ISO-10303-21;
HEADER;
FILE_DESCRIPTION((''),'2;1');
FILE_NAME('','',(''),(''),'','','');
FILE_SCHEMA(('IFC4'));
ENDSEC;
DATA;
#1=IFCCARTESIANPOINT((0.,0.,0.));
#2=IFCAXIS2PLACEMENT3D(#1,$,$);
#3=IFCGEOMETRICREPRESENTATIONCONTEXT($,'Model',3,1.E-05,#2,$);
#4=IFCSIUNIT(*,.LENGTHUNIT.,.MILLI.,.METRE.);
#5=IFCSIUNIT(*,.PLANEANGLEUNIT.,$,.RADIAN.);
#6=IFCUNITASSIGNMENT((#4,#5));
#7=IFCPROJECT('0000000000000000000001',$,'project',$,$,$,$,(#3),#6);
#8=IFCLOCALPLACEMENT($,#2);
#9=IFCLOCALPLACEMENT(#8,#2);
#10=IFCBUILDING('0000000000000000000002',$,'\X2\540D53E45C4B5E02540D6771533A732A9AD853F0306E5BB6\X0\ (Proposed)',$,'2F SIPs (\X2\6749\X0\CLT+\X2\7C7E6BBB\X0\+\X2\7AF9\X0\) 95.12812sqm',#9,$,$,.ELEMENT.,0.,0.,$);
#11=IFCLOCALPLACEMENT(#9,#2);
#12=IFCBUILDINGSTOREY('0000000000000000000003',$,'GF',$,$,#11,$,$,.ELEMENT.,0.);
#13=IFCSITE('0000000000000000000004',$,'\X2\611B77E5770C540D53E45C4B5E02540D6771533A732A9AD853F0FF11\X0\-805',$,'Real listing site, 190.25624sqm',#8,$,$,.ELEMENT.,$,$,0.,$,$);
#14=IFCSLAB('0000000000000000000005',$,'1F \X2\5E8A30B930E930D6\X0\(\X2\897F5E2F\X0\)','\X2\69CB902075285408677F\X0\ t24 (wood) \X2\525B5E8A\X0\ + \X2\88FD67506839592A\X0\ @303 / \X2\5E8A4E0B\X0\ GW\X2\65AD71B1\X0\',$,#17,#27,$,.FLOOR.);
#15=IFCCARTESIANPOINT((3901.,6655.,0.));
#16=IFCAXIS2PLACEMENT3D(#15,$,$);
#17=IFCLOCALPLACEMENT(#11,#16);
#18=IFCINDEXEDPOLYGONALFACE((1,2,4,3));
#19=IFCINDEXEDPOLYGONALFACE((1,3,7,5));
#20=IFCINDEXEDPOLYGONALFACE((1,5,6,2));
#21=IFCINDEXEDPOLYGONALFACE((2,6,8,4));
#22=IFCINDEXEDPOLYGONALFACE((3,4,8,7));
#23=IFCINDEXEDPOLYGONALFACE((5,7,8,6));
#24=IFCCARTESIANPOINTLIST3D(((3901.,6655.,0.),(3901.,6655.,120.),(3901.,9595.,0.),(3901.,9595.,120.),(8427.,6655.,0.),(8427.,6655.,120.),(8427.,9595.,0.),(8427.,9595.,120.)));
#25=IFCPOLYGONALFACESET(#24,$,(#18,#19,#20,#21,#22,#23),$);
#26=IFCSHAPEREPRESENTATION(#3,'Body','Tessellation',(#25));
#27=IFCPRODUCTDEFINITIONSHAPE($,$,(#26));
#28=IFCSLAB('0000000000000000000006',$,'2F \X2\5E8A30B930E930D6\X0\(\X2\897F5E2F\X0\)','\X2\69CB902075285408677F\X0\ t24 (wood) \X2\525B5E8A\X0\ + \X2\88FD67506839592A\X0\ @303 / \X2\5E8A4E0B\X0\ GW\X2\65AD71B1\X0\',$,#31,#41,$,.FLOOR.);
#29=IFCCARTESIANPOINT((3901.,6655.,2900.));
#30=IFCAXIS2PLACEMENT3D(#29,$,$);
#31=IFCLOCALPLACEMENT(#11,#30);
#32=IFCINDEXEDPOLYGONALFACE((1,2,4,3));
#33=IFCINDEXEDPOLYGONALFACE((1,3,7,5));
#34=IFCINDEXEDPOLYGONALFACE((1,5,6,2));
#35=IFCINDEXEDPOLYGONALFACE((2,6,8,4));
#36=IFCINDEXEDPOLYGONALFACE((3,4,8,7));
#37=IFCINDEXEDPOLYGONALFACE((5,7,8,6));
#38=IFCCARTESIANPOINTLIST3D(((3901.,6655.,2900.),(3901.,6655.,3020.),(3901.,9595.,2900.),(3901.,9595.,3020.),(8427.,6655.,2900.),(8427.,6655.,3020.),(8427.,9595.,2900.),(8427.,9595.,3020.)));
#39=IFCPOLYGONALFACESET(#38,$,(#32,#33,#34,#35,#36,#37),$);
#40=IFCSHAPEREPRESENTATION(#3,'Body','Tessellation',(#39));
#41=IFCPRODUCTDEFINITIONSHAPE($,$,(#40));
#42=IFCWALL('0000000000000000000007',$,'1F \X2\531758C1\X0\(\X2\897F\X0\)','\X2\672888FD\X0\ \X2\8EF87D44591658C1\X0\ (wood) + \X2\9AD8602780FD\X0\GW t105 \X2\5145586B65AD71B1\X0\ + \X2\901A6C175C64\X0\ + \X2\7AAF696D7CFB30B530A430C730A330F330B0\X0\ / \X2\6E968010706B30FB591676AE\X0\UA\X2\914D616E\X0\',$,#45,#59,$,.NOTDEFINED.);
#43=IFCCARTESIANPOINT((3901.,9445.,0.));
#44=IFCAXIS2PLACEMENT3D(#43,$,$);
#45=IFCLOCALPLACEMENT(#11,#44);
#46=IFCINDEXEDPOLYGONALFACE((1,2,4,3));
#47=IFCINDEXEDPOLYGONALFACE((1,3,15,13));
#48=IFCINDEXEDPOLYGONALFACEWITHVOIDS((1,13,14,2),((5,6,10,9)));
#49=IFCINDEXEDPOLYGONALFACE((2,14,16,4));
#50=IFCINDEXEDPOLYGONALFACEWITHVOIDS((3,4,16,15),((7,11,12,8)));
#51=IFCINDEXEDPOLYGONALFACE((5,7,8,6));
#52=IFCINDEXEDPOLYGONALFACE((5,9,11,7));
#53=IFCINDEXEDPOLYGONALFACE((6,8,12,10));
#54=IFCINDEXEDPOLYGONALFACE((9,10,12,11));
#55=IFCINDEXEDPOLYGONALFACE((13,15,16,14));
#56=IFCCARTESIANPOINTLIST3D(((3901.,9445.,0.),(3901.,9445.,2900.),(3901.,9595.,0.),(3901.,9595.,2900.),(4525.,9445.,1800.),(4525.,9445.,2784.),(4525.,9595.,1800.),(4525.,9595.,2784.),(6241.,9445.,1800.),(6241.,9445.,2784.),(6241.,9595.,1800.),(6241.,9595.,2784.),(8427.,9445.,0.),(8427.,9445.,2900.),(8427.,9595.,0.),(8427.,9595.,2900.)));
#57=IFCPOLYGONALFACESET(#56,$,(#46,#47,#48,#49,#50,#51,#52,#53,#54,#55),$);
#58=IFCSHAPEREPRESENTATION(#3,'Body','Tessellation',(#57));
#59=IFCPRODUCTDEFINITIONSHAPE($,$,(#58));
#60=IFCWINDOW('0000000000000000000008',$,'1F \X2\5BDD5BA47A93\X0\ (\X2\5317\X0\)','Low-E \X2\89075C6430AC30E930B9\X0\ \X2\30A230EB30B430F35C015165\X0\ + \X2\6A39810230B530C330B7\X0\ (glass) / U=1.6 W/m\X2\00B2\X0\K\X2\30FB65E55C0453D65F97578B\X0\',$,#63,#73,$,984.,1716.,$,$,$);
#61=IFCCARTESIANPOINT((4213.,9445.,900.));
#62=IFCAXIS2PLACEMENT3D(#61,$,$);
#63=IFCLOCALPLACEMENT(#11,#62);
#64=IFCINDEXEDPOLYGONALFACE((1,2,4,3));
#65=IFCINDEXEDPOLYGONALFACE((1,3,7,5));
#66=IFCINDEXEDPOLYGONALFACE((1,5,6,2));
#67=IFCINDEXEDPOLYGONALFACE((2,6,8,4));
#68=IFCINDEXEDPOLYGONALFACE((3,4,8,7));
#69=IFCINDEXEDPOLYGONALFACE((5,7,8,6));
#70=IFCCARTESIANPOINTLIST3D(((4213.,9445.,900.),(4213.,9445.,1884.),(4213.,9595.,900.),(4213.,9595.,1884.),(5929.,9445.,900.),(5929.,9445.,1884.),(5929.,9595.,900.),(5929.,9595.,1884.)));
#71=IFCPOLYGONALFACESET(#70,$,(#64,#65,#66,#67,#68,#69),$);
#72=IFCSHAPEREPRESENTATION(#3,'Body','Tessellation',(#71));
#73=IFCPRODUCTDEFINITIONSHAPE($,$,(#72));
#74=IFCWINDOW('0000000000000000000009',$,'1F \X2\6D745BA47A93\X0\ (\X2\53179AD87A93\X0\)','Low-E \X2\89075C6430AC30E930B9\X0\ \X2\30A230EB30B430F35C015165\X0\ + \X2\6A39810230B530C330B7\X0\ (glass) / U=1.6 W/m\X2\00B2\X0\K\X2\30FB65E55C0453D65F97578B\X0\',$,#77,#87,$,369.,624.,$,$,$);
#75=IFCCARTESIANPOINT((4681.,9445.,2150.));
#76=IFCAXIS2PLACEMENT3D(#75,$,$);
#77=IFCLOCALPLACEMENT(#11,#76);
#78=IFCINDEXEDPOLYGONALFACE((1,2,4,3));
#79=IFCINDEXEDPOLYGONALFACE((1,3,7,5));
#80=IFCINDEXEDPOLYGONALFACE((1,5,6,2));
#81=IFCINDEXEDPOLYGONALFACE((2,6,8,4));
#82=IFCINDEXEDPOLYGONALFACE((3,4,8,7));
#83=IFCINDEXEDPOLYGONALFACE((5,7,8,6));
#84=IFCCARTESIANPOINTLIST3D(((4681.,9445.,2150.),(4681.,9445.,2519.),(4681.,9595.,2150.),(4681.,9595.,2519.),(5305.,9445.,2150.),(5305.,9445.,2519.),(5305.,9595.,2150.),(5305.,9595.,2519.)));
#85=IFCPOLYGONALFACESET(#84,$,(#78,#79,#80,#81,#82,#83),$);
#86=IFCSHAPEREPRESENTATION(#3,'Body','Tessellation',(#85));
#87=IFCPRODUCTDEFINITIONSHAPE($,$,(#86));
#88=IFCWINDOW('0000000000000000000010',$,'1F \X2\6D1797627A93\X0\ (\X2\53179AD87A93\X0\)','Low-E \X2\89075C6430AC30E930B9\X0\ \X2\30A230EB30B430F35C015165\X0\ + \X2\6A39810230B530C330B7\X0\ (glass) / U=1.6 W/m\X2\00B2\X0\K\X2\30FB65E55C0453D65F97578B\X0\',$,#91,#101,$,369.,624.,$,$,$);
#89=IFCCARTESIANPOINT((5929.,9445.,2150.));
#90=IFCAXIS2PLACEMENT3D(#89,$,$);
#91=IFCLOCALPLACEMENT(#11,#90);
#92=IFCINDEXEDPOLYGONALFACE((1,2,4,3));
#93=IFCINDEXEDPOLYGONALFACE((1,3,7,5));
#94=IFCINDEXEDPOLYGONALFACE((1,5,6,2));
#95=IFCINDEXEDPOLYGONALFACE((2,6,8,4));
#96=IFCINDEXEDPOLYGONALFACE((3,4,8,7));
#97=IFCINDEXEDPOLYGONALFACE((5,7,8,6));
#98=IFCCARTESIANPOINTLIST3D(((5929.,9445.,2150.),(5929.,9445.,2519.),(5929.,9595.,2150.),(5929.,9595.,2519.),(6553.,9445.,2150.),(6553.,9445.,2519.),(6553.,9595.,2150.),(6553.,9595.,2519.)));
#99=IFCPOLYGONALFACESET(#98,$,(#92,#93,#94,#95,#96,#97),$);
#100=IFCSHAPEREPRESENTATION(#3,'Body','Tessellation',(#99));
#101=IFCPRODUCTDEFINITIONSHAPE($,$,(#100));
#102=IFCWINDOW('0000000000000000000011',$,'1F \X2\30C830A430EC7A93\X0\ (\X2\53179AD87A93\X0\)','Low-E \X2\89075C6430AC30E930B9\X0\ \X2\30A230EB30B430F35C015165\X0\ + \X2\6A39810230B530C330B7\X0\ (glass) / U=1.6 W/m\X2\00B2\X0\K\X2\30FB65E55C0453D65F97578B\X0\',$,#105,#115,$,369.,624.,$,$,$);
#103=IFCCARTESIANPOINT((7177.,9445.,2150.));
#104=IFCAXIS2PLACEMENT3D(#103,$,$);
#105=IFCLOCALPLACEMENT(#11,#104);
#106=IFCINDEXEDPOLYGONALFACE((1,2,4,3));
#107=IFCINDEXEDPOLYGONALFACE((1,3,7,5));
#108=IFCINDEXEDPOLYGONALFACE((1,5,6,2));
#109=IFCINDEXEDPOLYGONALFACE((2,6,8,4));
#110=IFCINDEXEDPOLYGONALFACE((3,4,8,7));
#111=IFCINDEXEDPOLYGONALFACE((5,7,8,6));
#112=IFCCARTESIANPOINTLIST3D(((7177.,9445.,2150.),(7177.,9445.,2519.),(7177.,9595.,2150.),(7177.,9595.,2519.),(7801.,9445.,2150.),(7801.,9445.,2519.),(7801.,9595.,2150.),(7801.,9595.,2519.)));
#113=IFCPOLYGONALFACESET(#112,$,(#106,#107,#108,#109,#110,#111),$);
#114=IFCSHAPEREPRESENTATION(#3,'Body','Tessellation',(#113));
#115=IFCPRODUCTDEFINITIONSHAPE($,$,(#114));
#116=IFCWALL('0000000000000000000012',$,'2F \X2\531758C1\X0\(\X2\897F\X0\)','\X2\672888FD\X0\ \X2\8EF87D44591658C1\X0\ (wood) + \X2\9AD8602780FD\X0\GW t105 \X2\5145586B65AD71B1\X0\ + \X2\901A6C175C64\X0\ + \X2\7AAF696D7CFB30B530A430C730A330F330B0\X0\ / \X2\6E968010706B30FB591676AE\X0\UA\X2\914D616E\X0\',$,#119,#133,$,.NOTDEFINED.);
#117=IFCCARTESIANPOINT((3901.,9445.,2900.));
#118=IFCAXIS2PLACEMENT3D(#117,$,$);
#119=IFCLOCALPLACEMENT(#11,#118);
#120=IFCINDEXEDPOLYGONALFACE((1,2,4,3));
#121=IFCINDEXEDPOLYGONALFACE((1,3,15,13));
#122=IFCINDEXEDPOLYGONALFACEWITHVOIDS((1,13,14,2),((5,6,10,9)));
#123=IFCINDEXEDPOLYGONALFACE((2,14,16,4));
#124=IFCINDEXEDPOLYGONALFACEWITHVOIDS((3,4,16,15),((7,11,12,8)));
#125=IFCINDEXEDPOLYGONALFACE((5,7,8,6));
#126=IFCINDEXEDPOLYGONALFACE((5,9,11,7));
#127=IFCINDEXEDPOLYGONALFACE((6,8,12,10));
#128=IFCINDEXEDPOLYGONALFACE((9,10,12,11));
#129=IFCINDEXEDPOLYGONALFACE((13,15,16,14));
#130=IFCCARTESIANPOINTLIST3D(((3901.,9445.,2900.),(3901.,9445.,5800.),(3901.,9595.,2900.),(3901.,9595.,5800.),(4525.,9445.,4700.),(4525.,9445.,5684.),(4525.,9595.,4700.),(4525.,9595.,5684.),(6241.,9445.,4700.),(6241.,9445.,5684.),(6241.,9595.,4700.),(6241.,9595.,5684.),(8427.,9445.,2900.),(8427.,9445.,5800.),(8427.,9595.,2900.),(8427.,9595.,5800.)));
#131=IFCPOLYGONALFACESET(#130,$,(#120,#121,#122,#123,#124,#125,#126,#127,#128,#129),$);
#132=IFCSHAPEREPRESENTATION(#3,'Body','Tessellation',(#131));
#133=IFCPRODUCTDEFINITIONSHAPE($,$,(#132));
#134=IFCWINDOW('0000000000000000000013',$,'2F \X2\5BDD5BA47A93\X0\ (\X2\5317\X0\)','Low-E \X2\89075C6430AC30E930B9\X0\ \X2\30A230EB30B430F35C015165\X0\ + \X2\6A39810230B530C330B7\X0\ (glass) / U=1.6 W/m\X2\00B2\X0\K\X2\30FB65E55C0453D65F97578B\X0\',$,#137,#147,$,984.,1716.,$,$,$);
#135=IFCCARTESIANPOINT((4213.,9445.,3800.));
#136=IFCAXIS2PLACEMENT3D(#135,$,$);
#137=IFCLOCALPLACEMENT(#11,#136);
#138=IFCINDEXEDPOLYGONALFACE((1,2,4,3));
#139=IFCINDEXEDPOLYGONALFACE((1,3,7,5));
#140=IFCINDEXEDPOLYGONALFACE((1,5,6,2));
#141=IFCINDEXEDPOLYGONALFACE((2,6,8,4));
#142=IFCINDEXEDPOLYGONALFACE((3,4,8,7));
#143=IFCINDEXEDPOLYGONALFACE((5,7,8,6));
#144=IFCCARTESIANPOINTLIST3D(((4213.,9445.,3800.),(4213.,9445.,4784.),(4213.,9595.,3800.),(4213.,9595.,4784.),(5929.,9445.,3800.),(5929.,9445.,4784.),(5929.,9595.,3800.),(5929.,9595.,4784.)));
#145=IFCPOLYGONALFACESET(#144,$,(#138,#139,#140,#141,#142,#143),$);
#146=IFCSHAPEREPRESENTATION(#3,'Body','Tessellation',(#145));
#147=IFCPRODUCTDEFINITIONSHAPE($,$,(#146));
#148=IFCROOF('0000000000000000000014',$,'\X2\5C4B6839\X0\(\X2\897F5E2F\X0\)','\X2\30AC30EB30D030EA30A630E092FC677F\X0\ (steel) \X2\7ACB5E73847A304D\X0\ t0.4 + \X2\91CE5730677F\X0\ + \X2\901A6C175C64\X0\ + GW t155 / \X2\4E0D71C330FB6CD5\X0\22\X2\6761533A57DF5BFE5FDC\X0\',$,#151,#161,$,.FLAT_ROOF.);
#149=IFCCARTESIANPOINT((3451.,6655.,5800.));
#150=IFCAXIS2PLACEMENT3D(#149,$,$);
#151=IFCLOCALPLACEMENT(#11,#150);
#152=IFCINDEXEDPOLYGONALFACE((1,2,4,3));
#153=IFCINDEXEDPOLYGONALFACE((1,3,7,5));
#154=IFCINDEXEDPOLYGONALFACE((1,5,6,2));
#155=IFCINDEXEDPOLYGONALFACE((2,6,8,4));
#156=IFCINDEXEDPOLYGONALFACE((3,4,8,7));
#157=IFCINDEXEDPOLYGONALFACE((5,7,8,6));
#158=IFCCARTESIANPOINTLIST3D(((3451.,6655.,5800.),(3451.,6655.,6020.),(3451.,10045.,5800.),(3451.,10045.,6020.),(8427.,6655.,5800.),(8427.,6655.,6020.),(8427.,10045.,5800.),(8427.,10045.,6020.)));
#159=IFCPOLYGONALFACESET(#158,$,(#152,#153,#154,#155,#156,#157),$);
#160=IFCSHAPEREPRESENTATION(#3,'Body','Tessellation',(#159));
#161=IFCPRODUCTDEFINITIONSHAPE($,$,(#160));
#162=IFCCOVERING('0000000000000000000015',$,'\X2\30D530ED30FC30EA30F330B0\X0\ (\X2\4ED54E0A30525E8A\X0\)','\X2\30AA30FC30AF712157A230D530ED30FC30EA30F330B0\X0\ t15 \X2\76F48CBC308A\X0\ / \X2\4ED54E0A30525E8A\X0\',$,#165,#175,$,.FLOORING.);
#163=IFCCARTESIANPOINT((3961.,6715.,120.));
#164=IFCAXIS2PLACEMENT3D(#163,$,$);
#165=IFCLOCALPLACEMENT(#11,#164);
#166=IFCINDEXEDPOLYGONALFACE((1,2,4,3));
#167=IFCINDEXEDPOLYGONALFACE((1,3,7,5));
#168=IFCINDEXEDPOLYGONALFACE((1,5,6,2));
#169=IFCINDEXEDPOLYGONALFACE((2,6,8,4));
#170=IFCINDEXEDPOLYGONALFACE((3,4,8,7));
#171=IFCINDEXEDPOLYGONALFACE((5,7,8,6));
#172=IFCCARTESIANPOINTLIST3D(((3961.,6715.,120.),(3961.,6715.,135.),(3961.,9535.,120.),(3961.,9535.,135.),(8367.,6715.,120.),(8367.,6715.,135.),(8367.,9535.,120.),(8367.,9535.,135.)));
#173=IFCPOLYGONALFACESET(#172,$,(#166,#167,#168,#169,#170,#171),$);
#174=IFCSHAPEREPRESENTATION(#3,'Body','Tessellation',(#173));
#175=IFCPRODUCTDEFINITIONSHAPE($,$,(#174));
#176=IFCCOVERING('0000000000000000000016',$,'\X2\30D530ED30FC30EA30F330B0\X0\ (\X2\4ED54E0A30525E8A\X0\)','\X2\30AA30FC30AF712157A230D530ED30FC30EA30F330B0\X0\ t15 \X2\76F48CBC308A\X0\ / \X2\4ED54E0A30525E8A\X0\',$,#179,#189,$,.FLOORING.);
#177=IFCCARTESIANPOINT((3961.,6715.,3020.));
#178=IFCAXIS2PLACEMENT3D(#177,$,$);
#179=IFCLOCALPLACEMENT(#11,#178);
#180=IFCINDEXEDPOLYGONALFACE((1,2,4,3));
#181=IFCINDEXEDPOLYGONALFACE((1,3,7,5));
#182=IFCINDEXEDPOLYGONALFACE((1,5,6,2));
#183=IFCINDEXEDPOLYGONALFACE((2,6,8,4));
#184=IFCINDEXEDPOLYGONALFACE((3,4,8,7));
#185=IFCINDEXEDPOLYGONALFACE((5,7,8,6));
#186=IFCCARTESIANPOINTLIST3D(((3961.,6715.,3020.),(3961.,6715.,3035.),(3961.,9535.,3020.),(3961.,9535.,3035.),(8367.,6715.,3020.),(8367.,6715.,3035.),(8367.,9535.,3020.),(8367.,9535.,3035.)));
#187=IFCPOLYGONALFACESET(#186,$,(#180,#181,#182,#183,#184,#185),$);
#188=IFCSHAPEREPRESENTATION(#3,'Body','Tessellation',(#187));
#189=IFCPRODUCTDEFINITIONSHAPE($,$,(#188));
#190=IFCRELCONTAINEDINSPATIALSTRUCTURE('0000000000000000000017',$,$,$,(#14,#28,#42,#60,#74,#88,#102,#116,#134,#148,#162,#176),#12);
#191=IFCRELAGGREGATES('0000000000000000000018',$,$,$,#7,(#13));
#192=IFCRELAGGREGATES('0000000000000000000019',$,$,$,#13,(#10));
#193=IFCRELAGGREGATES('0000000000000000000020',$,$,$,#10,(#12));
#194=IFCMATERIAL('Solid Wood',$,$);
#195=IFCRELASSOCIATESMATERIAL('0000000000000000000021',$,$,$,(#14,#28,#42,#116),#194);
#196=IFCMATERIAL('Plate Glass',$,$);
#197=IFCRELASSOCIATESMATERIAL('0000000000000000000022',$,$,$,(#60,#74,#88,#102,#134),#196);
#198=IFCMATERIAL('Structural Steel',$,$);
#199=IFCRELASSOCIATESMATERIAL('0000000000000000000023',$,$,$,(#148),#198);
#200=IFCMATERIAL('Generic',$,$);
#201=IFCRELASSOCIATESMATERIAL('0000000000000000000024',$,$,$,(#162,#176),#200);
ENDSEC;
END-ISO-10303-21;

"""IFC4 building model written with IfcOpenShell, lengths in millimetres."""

from ifc_helpers import new_model, si_unit, frame, frame_2d, origin, place, context, project, spatial, rectangle, extrude, material, element, fill, save


model = new_model("IFC4")

# Units and contexts
model_context = context("Model", 3, precision=1e-05, world=origin())
ifc_project = project(units=[si_unit("LENGTHUNIT", "METRE", prefix="MILLI"), si_unit("PLANEANGLEUNIT", "RADIAN")], contexts=[model_context])

# Site, building, storey
site_placement = place(None, origin())
site = spatial("IfcSite", under=ifc_project, at=site_placement, Name="愛知県名古屋市名東区猪高台１-805", ObjectType="Real listing site, 190.25624sqm", CompositionType="ELEMENT", RefElevation=0.0)
building_placement = place(site_placement, origin())
building = spatial("IfcBuilding", under=site, at=building_placement, Name="名古屋市名東区猪高台の家 (Proposed)", ObjectType="2F SIPs (杉CLT+籾殻+竹) 95.12812sqm", CompositionType="ELEMENT", ElevationOfRefHeight=0.0, ElevationOfTerrain=0.0)
storey_placement = place(building_placement, origin())
storey = spatial("IfcBuildingStorey", under=building, at=storey_placement, Name="GF", CompositionType="ELEMENT", Elevation=0.0)

# Slabs
ifc_material_1 = material(Name="Solid Wood")
slab_1_placement = place(storey_placement, frame((3901.0, 6655.0, 0.0)))
element("IfcSlab", 1, at=slab_1_placement, inside=storey, material=ifc_material_1, Name="1F 床スラブ(西帯)", Description="構造用合板 t24 (wood) 剛床 + 製材根太 @303 / 床下 GW断熱", PredefinedType="FLOOR", context=model_context, shape_type="SweptSolid", body=[
    extrude(rectangle(XDim=4526.0, YDim=2940.0, at=frame_2d((2263.0, 1470.0))), frame((3901.0, 6655.0, 0.0)), (0.0, 0.0, 1.0), 120.0),
])
slab_2_placement = place(storey_placement, frame((3901.0, 6655.0, 2900.0)))
element("IfcSlab", 2, at=slab_2_placement, inside=storey, material=ifc_material_1, Name="2F 床スラブ(西帯)", Description="構造用合板 t24 (wood) 剛床 + 製材根太 @303 / 床下 GW断熱", PredefinedType="FLOOR", context=model_context, shape_type="SweptSolid", body=[
    extrude(rectangle(XDim=4526.0, YDim=2940.0, at=frame_2d((2263.0, 1470.0))), frame((3901.0, 6655.0, 2900.0)), (0.0, 0.0, 1.0), 120.0),
])

# Wall, openings, windows
wall_1_placement = place(storey_placement, frame((3901.0, 9445.0, 0.0)))
wall_1 = element("IfcWall", 3, at=wall_1_placement, inside=storey, material=ifc_material_1, Name="1F 北壁(西)", Description="木製 軸組外壁 (wood) + 高性能GW t105 充填断熱 + 通気層 + 窯業系サイディング / 準耐火・外皮UA配慮", PredefinedType="NOTDEFINED", context=model_context, shape_type="SweptSolid", body=[
    extrude(rectangle(XDim=4526.0, YDim=150.0, at=frame_2d((2263.0, 75.0))), frame((3901.0, 9445.0, 0.0)), (0.0, 0.0, 1.0), 2900.0),
])
opening_1_placement = place(storey_placement, frame((4213.0, 9445.0, 900.0)))
opening_1 = element("IfcOpeningElement", 4, at=opening_1_placement, cuts=wall_1, PredefinedType="NOTDEFINED", context=model_context, shape_type="SweptSolid", body=[
    extrude(rectangle(XDim=1716.0, YDim=150.0, at=frame_2d((858.0, 75.0))), frame((4213.0, 9445.0, 900.0)), (0.0, 0.0, 1.0), 984.0),
])
opening_2_placement = place(storey_placement, frame((4681.0, 9445.0, 2150.0)))
opening_2 = element("IfcOpeningElement", 5, at=opening_2_placement, cuts=wall_1, PredefinedType="NOTDEFINED", context=model_context, shape_type="SweptSolid", body=[
    extrude(rectangle(XDim=624.0, YDim=150.0, at=frame_2d((312.0, 75.0))), frame((4681.0, 9445.0, 2150.0)), (0.0, 0.0, 1.0), 369.0),
])
opening_3_placement = place(storey_placement, frame((5929.0, 9445.0, 2150.0)))
opening_3 = element("IfcOpeningElement", 6, at=opening_3_placement, cuts=wall_1, PredefinedType="NOTDEFINED", context=model_context, shape_type="SweptSolid", body=[
    extrude(rectangle(XDim=624.0, YDim=150.0, at=frame_2d((312.0, 75.0))), frame((5929.0, 9445.0, 2150.0)), (0.0, 0.0, 1.0), 369.0),
])
opening_4_placement = place(storey_placement, frame((7177.0, 9445.0, 2150.0)))
opening_4 = element("IfcOpeningElement", 7, at=opening_4_placement, cuts=wall_1, PredefinedType="NOTDEFINED", context=model_context, shape_type="SweptSolid", body=[
    extrude(rectangle(XDim=624.0, YDim=150.0, at=frame_2d((312.0, 75.0))), frame((7177.0, 9445.0, 2150.0)), (0.0, 0.0, 1.0), 369.0),
])
ifc_material_2 = material(Name="Plate Glass")
window_1_placement = place(storey_placement, frame((4213.0, 9445.0, 900.0)))
window_1 = element("IfcWindow", 8, at=window_1_placement, inside=storey, material=ifc_material_2, Name="1F 寝室窓 (北)", Description="Low-E 複層ガラス アルゴン封入 + 樹脂サッシ (glass) / U=1.6 W/m²K・日射取得型", OverallHeight=984.0, OverallWidth=1716.0, context=model_context, shape_type="SweptSolid", body=[
    extrude(rectangle(XDim=1716.0, YDim=150.0, at=frame_2d((858.0, 75.0))), frame((4213.0, 9445.0, 900.0)), (0.0, 0.0, 1.0), 984.0),
])
fill(opening_1, window_1)
window_2_placement = place(storey_placement, frame((4681.0, 9445.0, 2150.0)))
window_2 = element("IfcWindow", 9, at=window_2_placement, inside=storey, material=ifc_material_2, Name="1F 浴室窓 (北高窓)", Description="Low-E 複層ガラス アルゴン封入 + 樹脂サッシ (glass) / U=1.6 W/m²K・日射取得型", OverallHeight=369.0, OverallWidth=624.0, context=model_context, shape_type="SweptSolid", body=[
    extrude(rectangle(XDim=624.0, YDim=150.0, at=frame_2d((312.0, 75.0))), frame((4681.0, 9445.0, 2150.0)), (0.0, 0.0, 1.0), 369.0),
])
fill(opening_2, window_2)
window_3_placement = place(storey_placement, frame((5929.0, 9445.0, 2150.0)))
window_3 = element("IfcWindow", 10, at=window_3_placement, inside=storey, material=ifc_material_2, Name="1F 洗面窓 (北高窓)", Description="Low-E 複層ガラス アルゴン封入 + 樹脂サッシ (glass) / U=1.6 W/m²K・日射取得型", OverallHeight=369.0, OverallWidth=624.0, context=model_context, shape_type="SweptSolid", body=[
    extrude(rectangle(XDim=624.0, YDim=150.0, at=frame_2d((312.0, 75.0))), frame((5929.0, 9445.0, 2150.0)), (0.0, 0.0, 1.0), 369.0),
])
fill(opening_3, window_3)
window_4_placement = place(storey_placement, frame((7177.0, 9445.0, 2150.0)))
window_4 = element("IfcWindow", 11, at=window_4_placement, inside=storey, material=ifc_material_2, Name="1F トイレ窓 (北高窓)", Description="Low-E 複層ガラス アルゴン封入 + 樹脂サッシ (glass) / U=1.6 W/m²K・日射取得型", OverallHeight=369.0, OverallWidth=624.0, context=model_context, shape_type="SweptSolid", body=[
    extrude(rectangle(XDim=624.0, YDim=150.0, at=frame_2d((312.0, 75.0))), frame((7177.0, 9445.0, 2150.0)), (0.0, 0.0, 1.0), 369.0),
])
fill(opening_4, window_4)

# Wall, opening, window
wall_2_placement = place(storey_placement, frame((3901.0, 9445.0, 2900.0)))
wall_2 = element("IfcWall", 12, at=wall_2_placement, inside=storey, material=ifc_material_1, Name="2F 北壁(西)", Description="木製 軸組外壁 (wood) + 高性能GW t105 充填断熱 + 通気層 + 窯業系サイディング / 準耐火・外皮UA配慮", PredefinedType="NOTDEFINED", context=model_context, shape_type="SweptSolid", body=[
    extrude(rectangle(XDim=4526.0, YDim=150.0, at=frame_2d((2263.0, 75.0))), frame((3901.0, 9445.0, 2900.0)), (0.0, 0.0, 1.0), 2900.0),
])
opening_5_placement = place(storey_placement, frame((4213.0, 9445.0, 3800.0)))
opening_5 = element("IfcOpeningElement", 13, at=opening_5_placement, cuts=wall_2, PredefinedType="NOTDEFINED", context=model_context, shape_type="SweptSolid", body=[
    extrude(rectangle(XDim=1716.0, YDim=150.0, at=frame_2d((858.0, 75.0))), frame((4213.0, 9445.0, 3800.0)), (0.0, 0.0, 1.0), 984.0),
])
window_5_placement = place(storey_placement, frame((4213.0, 9445.0, 3800.0)))
window_5 = element("IfcWindow", 14, at=window_5_placement, inside=storey, material=ifc_material_2, Name="2F 寝室窓 (北)", Description="Low-E 複層ガラス アルゴン封入 + 樹脂サッシ (glass) / U=1.6 W/m²K・日射取得型", OverallHeight=984.0, OverallWidth=1716.0, context=model_context, shape_type="SweptSolid", body=[
    extrude(rectangle(XDim=1716.0, YDim=150.0, at=frame_2d((858.0, 75.0))), frame((4213.0, 9445.0, 3800.0)), (0.0, 0.0, 1.0), 984.0),
])
fill(opening_5, window_5)

# Roof
ifc_material_3 = material(Name="Structural Steel")
for number, where, name in (
    (15, (3451.0, 6655.0, 5800.0), "屋根(西帯)"),
):
    element("IfcRoof", number, at=place(storey_placement, frame(where)), inside=storey, material=ifc_material_3, Name=name, Description="ガルバリウム鋼板 (steel) 立平葺き t0.4 + 野地板 + 通気層 + GW t155 / 不燃・法22条区域対応", PredefinedType="FLAT_ROOF", context=model_context, shape_type="SweptSolid", body=[
        extrude(rectangle(XDim=4976.0, YDim=3390.0, at=frame_2d((2488.0, 1695.0))), frame((3451.0, 6655.0, 5800.0)), (0.0, 0.0, 1.0), 220.0),
    ])

# Coverings
ifc_material_4 = material(Name="Generic")
covering_1_placement = place(storey_placement, frame((3961.0, 6715.0, 120.0)))
element("IfcCovering", 16, at=covering_1_placement, inside=storey, material=ifc_material_4, Name="フローリング (仕上げ床)", Description="オーク無垢フローリング t15 直貼り / 仕上げ床", PredefinedType="FLOORING", context=model_context, shape_type="SweptSolid", body=[
    extrude(rectangle(XDim=4406.0, YDim=2820.0, at=frame_2d((2203.0, 1410.0))), frame((3961.0, 6715.0, 120.0)), (0.0, 0.0, 1.0), 15.0),
])
covering_2_placement = place(storey_placement, frame((3961.0, 6715.0, 3020.0)))
element("IfcCovering", 17, at=covering_2_placement, inside=storey, material=ifc_material_4, Name="フローリング (仕上げ床)", Description="オーク無垢フローリング t15 直貼り / 仕上げ床", PredefinedType="FLOORING", context=model_context, shape_type="SweptSolid", body=[
    extrude(rectangle(XDim=4406.0, YDim=2820.0, at=frame_2d((2203.0, 1410.0))), frame((3961.0, 6715.0, 3020.0)), (0.0, 0.0, 1.0), 15.0),
])

save(model, "model.ifc")
